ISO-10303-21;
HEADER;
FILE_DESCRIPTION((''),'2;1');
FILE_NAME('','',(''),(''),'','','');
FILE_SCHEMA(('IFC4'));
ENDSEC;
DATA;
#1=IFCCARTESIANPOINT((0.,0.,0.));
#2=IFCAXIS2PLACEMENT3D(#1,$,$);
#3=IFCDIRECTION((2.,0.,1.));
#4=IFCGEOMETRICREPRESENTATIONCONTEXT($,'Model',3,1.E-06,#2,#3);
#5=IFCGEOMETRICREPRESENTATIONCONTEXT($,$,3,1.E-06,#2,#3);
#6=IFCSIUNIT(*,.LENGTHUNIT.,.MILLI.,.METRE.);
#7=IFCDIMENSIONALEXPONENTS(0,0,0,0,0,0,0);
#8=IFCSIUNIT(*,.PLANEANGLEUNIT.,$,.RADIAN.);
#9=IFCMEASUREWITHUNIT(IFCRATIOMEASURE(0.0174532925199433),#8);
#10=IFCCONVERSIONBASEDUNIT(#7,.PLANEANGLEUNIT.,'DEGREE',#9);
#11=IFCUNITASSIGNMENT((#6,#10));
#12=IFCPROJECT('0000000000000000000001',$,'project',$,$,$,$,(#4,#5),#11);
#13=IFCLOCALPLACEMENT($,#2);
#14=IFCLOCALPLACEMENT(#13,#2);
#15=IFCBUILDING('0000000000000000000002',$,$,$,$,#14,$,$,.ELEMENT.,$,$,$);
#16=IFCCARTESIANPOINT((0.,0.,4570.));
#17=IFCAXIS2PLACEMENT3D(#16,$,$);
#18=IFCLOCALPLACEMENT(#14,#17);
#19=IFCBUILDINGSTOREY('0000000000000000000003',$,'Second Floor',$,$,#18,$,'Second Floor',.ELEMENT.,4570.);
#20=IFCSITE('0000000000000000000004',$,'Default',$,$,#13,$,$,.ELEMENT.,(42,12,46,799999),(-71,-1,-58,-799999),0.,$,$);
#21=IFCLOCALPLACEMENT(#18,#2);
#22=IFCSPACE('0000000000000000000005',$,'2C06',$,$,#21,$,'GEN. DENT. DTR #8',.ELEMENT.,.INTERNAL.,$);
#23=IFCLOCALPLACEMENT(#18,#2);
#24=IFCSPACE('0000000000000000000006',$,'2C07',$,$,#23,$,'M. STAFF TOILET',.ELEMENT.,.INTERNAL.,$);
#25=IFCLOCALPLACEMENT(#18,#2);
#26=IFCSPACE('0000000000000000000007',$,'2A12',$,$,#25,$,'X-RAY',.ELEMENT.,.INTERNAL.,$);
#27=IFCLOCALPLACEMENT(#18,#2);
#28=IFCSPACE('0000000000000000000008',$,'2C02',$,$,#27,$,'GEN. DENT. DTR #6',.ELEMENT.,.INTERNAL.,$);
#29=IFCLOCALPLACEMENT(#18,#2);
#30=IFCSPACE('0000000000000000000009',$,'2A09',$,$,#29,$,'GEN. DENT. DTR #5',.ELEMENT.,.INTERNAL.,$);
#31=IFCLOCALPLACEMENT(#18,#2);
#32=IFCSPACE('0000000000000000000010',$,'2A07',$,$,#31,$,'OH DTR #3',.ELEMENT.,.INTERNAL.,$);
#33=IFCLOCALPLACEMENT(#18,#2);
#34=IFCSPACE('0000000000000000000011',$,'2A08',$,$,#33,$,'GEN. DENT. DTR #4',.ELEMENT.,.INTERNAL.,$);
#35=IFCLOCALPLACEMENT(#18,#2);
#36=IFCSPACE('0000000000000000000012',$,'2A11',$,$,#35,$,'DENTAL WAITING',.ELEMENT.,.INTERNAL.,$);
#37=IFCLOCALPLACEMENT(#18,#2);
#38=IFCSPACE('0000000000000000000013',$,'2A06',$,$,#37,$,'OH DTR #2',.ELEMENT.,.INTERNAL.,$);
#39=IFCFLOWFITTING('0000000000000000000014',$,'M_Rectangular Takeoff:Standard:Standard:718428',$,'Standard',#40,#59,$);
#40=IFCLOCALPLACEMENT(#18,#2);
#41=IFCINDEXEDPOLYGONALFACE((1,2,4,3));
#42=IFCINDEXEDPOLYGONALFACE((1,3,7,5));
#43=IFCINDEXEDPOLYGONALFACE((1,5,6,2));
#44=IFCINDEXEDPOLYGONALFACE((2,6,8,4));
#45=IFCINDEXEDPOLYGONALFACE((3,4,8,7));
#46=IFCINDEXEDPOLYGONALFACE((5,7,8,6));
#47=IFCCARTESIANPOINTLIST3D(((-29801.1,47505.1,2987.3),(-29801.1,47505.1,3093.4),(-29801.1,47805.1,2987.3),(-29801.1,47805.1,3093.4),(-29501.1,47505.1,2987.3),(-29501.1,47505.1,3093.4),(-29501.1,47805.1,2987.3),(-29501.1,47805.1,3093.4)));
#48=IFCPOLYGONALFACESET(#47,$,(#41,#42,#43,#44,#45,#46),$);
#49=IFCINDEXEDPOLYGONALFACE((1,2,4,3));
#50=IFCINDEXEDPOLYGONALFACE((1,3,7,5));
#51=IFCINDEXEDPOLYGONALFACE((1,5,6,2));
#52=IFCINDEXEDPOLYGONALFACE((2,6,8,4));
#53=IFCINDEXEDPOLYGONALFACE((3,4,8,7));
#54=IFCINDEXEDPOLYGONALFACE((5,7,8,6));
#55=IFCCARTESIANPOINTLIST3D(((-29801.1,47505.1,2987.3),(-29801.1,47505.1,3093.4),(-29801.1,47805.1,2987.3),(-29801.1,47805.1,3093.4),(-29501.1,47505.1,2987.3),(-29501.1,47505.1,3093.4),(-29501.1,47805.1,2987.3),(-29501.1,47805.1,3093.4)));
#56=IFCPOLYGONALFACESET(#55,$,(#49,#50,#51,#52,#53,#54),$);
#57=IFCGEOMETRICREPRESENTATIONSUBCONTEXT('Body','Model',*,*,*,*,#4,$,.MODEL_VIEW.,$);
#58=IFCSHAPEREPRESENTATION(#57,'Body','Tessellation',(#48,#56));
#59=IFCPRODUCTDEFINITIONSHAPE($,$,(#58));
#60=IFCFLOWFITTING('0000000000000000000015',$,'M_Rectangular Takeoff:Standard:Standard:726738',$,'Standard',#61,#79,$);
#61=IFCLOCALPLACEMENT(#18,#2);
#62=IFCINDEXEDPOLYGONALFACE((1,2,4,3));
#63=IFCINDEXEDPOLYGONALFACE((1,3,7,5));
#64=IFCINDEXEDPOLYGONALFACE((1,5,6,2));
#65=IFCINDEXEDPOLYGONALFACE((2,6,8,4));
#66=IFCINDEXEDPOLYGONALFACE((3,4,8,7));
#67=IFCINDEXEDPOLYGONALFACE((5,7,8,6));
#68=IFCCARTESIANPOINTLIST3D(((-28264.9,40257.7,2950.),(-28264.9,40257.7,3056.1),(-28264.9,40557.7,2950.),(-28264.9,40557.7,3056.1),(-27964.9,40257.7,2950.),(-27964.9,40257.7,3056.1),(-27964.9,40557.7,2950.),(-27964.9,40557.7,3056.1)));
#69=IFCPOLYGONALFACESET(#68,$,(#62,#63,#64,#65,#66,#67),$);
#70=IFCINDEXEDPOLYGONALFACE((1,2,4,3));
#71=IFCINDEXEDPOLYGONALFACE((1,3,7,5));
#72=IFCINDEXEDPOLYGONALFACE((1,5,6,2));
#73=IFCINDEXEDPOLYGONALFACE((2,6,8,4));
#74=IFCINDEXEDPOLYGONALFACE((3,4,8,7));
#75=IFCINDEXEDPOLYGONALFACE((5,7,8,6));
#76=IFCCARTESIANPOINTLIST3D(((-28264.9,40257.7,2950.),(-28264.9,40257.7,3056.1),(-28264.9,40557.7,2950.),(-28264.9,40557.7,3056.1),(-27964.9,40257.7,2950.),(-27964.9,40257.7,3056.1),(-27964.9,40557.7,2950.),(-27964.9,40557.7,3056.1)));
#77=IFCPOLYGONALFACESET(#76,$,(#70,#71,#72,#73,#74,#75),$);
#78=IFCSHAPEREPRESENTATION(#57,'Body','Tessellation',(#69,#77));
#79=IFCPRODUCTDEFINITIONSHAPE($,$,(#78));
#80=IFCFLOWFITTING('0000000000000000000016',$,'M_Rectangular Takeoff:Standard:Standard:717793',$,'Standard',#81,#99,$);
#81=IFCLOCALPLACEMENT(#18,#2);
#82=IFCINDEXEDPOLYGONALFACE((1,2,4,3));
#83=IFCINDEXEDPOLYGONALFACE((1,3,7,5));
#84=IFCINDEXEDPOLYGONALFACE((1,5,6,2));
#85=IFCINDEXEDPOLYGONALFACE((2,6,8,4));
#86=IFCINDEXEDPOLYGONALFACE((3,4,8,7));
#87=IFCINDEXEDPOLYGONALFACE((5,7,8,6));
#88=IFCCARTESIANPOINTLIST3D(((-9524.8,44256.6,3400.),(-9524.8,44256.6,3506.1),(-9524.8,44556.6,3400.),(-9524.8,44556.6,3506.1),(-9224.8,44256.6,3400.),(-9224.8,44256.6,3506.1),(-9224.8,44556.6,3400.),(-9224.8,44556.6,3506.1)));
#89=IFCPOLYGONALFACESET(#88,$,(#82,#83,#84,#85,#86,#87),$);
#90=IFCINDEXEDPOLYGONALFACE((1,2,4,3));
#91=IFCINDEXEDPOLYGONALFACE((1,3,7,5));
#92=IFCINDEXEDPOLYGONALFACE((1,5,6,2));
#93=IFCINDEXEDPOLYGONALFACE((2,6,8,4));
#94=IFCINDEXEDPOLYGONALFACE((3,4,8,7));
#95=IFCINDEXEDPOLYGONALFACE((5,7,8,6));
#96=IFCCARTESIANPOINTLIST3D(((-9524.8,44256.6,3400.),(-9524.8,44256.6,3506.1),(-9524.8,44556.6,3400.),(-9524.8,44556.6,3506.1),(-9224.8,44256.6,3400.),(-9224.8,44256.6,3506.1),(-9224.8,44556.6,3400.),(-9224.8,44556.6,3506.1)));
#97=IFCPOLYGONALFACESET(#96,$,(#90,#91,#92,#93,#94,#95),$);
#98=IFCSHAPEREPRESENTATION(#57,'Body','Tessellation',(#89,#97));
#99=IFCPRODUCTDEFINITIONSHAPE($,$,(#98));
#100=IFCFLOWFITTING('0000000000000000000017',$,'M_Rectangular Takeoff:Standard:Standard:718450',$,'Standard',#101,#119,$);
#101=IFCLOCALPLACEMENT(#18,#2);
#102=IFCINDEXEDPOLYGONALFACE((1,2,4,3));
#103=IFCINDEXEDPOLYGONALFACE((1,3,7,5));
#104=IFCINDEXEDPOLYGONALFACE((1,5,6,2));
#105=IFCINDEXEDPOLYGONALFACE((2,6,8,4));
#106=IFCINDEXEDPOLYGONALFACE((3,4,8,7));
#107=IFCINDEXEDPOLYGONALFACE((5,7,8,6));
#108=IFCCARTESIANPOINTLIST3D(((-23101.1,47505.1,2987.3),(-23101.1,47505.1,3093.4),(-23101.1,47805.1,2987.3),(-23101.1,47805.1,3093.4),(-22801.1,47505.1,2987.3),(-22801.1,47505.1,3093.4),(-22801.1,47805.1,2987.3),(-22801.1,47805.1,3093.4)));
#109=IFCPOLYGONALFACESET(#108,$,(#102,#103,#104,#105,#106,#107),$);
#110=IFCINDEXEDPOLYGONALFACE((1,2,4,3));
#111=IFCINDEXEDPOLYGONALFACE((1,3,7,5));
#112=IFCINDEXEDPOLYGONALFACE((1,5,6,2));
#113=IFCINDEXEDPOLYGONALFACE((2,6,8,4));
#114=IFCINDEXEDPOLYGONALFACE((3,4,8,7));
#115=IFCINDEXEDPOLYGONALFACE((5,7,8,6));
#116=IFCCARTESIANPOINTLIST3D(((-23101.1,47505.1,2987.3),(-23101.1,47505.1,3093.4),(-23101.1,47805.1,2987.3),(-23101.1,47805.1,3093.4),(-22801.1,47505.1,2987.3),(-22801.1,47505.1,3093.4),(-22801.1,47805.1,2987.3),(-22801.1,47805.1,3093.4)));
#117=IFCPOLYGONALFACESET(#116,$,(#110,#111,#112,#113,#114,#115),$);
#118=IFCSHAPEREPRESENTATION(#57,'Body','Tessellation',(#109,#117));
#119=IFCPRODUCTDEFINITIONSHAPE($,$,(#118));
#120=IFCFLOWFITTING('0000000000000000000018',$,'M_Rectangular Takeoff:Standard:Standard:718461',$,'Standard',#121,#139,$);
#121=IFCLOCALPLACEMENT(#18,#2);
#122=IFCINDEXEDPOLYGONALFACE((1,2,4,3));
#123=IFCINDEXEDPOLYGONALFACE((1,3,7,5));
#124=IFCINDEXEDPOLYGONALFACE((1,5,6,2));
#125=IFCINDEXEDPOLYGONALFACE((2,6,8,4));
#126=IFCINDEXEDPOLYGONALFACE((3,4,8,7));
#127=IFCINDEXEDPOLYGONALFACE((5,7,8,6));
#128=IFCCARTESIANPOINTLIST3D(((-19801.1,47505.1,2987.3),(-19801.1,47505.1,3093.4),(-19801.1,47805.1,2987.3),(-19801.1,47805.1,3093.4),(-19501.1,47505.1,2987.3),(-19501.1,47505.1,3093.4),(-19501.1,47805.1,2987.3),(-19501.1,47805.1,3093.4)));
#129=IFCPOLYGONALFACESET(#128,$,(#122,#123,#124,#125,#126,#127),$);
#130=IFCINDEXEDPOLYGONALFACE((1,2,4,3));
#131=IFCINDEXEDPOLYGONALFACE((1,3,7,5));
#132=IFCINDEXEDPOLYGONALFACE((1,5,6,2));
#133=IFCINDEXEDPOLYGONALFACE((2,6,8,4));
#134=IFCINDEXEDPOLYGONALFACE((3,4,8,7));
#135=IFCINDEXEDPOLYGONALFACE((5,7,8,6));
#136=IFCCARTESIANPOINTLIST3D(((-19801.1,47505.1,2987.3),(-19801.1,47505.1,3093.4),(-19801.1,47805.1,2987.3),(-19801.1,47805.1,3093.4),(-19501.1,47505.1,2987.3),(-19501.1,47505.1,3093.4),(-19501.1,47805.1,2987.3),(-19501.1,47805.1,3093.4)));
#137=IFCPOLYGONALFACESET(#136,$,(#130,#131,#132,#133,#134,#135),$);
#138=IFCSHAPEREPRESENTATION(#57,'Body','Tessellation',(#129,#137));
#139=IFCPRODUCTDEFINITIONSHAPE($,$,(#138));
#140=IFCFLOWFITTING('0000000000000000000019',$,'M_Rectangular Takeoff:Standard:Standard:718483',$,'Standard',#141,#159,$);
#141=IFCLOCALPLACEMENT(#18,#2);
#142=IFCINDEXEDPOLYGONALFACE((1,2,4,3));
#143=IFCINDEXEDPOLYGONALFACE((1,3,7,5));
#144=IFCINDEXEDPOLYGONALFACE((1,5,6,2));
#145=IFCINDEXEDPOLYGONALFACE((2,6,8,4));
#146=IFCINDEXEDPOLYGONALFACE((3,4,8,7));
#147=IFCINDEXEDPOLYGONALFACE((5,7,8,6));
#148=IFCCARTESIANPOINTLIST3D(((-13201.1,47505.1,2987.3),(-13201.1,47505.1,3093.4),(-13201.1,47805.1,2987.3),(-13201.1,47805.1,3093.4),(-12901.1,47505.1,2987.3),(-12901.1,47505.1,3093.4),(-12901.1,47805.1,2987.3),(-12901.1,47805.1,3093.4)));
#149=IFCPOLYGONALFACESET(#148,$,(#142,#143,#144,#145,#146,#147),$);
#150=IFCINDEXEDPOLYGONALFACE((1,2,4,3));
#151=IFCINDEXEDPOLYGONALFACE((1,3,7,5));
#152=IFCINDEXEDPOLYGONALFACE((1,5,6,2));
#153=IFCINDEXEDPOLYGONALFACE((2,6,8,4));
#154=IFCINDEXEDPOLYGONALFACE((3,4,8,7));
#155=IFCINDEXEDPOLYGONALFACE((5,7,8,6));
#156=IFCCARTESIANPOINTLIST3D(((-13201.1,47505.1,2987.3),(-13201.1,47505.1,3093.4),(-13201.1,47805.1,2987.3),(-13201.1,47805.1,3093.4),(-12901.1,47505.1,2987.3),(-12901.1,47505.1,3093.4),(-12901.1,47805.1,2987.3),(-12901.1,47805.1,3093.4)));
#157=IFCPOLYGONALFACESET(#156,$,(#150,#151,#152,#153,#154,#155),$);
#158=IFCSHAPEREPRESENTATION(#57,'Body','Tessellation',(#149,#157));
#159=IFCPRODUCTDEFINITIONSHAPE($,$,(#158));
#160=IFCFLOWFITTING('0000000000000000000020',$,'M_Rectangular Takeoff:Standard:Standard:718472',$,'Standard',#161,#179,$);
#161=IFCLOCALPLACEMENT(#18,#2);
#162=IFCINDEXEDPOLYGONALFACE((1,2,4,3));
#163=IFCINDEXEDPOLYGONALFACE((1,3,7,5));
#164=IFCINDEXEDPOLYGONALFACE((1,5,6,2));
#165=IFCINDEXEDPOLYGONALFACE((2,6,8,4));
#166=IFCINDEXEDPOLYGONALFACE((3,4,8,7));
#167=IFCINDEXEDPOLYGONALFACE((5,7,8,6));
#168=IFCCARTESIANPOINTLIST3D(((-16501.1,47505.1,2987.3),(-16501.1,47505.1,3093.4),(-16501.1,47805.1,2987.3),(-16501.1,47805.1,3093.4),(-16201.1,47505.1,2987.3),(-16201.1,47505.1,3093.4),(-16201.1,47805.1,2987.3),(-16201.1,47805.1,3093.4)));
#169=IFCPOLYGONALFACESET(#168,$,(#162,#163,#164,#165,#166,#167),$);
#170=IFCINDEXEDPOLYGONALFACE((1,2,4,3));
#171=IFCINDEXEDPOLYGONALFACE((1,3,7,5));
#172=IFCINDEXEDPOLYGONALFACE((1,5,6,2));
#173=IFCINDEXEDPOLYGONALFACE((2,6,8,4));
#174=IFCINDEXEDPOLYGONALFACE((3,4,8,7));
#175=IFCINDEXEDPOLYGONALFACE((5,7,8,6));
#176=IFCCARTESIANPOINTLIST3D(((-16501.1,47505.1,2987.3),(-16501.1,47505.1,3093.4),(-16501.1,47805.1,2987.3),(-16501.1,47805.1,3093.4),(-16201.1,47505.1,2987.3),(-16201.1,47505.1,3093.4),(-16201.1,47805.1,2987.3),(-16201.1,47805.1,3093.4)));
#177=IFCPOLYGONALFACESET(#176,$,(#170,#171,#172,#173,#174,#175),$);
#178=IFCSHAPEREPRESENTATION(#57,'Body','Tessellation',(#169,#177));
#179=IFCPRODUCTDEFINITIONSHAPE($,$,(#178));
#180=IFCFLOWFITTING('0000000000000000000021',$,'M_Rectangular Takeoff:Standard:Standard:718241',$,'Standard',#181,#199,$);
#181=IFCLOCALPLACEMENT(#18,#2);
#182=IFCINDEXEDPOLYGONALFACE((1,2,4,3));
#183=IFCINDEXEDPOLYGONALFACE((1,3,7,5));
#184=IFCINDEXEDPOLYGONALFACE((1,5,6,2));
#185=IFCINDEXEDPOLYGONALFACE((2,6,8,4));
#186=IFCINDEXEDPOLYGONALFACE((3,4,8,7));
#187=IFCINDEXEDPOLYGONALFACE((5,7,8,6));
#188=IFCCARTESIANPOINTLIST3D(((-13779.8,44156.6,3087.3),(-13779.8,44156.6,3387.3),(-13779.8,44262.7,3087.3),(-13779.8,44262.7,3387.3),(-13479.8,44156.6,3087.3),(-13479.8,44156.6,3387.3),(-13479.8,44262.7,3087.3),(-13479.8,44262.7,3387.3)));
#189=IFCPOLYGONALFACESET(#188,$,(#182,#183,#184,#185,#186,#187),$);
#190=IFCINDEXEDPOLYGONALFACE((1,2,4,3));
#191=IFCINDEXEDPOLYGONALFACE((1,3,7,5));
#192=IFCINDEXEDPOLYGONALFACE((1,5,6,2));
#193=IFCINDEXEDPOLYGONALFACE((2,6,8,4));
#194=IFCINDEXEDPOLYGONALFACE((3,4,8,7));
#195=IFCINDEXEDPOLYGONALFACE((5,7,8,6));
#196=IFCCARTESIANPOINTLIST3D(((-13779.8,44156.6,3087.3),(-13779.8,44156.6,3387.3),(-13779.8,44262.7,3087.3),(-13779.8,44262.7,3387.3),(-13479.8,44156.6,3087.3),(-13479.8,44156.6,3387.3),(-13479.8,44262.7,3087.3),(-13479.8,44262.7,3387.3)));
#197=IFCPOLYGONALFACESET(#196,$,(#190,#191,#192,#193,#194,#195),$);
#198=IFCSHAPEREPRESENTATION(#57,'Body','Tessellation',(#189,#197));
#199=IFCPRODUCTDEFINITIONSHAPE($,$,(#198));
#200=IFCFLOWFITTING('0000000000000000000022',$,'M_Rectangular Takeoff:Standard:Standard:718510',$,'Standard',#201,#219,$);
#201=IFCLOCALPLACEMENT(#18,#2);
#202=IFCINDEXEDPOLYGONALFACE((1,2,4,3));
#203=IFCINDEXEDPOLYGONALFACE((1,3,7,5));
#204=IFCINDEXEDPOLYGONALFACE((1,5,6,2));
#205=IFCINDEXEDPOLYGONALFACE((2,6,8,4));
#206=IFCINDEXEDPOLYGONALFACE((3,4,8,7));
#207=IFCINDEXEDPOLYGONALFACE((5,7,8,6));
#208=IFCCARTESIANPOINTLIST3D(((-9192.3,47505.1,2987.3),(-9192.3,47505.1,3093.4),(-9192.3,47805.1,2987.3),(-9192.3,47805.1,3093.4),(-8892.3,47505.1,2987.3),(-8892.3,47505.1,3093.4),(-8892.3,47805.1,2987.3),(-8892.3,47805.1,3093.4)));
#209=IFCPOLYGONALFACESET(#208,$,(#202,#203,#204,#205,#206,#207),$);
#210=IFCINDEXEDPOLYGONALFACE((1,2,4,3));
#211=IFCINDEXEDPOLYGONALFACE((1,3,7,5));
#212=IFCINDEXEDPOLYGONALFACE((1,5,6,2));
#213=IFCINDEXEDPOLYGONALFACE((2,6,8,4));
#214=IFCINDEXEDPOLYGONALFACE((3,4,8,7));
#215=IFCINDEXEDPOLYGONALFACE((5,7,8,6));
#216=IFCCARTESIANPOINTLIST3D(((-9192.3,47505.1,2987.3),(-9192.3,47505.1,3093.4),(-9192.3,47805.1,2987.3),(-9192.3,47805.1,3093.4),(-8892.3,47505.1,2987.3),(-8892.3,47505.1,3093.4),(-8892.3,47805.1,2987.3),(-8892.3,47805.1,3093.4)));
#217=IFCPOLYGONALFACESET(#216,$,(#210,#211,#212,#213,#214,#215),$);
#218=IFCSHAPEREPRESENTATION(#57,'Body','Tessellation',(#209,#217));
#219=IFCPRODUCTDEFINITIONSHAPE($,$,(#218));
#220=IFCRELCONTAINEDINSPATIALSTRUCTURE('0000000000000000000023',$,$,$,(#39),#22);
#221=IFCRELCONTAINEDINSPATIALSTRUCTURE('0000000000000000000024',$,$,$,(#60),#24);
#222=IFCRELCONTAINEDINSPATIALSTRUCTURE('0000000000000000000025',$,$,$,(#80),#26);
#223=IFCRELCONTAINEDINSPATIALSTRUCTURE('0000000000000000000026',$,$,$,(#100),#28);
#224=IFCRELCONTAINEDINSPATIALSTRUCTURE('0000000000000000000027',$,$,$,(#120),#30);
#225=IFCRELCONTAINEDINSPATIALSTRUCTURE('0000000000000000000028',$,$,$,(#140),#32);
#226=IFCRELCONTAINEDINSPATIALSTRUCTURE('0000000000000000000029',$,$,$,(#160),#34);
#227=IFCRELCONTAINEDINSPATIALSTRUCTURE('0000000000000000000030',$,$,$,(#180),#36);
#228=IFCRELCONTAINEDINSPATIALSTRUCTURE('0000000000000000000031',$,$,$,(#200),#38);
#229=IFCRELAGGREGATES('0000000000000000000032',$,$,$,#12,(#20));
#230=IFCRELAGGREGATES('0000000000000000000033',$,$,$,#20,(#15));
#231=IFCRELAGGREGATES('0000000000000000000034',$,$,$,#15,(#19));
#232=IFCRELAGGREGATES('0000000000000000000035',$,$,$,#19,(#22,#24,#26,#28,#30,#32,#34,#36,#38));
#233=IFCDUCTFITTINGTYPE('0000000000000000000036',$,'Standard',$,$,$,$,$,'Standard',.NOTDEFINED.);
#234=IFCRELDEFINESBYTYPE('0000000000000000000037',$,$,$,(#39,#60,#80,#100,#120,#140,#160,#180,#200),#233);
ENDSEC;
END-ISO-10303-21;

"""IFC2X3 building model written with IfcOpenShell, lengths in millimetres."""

from ifc_helpers import new_model, entity, si_unit, converted_unit, direction, frame, frame_2d, origin, place, context, subcontext, project, spatial, rectangle, extrude, source, transform, mapped, type_object, type_shapes, element, save


model = new_model("IFC2X3")

# Units and contexts
model_context = context("Model", 3, precision=1e-06, world=origin(), true_north=direction((2.0, 0.0, 1.0)))
context_of_model = context(None, 3, precision=1e-06, world=origin(), true_north=direction((2.0, 0.0, 1.0)))
body_context = subcontext(model_context, "Body", "Model", "MODEL_VIEW")
ifc_project = project(units=[si_unit("LENGTHUNIT", "METRE", prefix="MILLI"), converted_unit("PLANEANGLEUNIT", "DEGREE", entity("IfcRatioMeasure", 0.0174532925199433), si_unit("PLANEANGLEUNIT", "RADIAN"), dimensions=[0, 0, 0, 0, 0, 0, 0])], contexts=[model_context, context_of_model])

# Site, building, storey
site_placement = place(None, origin())
site = spatial("IfcSite", under=ifc_project, at=site_placement, Name="Default", CompositionType="ELEMENT", RefLatitude=(42, 12, 46, 799999), RefLongitude=(-71, -1, -58, -799999), RefElevation=0.0)
building_placement = place(site_placement, origin())
building = spatial("IfcBuilding", under=site, at=building_placement, CompositionType="ELEMENT")
storey_placement = place(building_placement, frame((0.0, 0.0, 4570.0)))
storey = spatial("IfcBuildingStorey", under=building, at=storey_placement, Name="Second Floor", LongName="Second Floor", CompositionType="ELEMENT", Elevation=4570.0)

# Shared definitions
space_1_placement = place(storey_placement, origin())
space_1 = spatial("IfcSpace", under=storey, at=space_1_placement, Name="2C06", LongName="GEN. DENT. DTR #8", CompositionType="ELEMENT", InteriorOrExteriorSpace="INTERNAL")

# Flow fitting
duct_fitting_type_1 = type_object("IfcDuctFittingType", Name="Standard", ElementType="Standard", PredefinedType="NOTDEFINED")
shared_shape_1 = source(origin(), body_context, "Body", "SweptSolid", [
    extrude(rectangle(XDim=300.0, YDim=106.1, at=frame_2d((0.0, 0.0), x_axis=(1.0, 0.0))), frame((47.0, 0.0, -150.0), z_axis=(0.0, 0.0, 1.0), x_axis=(0.0, -1.0, 0.0)), (0.0, 0.0, 1.0), 300.0),
    extrude(rectangle(XDim=300.0, YDim=106.1, at=frame_2d((0.0, 0.0), x_axis=(1.0, 0.0))), frame((47.0, 0.0, -150.0), z_axis=(0.0, 0.0, 1.0), x_axis=(0.0, -1.0, 0.0)), (0.0, 0.0, 1.0), 300.0),
])
type_shapes(duct_fitting_type_1, [shared_shape_1])
flow_fitting_1_placement = place(space_1_placement, frame((-29651.1, 47655.1, 3087.3), z_axis=(0.0, -1.0, 0.0), x_axis=(0.0, 0.0, -1.0)))
element("IfcFlowFitting", 1, at=flow_fitting_1_placement, inside=space_1, type_object=duct_fitting_type_1, Name="M_Rectangular Takeoff:Standard:Standard:718428", ObjectType="Standard", context=body_context, shape_type="MappedRepresentation", body=[
    mapped(shared_shape_1, transform((0.0, 0.0, 0.0), scale=1.0)),
])

# Shared definitions
space_2_placement = place(storey_placement, origin())
space_2 = spatial("IfcSpace", under=storey, at=space_2_placement, Name="2C07", LongName="M. STAFF TOILET", CompositionType="ELEMENT", InteriorOrExteriorSpace="INTERNAL")

# Flow fitting
flow_fitting_2_placement = place(space_2_placement, frame((-28114.9, 40407.7, 3050.0), z_axis=(0.0, -1.0, 0.0), x_axis=(0.0, 0.0, -1.0)))
element("IfcFlowFitting", 2, at=flow_fitting_2_placement, inside=space_2, type_object=duct_fitting_type_1, Name="M_Rectangular Takeoff:Standard:Standard:726738", ObjectType="Standard", context=body_context, shape_type="MappedRepresentation", body=[
    mapped(shared_shape_1, transform((0.0, 0.0, 0.0), scale=1.0)),
])

# Shared definitions
space_3_placement = place(storey_placement, origin())
space_3 = spatial("IfcSpace", under=storey, at=space_3_placement, Name="2A12", LongName="X-RAY", CompositionType="ELEMENT", InteriorOrExteriorSpace="INTERNAL")

# Flow fitting
flow_fitting_3_placement = place(space_3_placement, frame((-9374.8, 44406.6, 3500.0), z_axis=(-1.0, 0.0, 0.0), x_axis=(0.0, 0.0, -1.0)))
element("IfcFlowFitting", 3, at=flow_fitting_3_placement, inside=space_3, type_object=duct_fitting_type_1, Name="M_Rectangular Takeoff:Standard:Standard:717793", ObjectType="Standard", context=body_context, shape_type="MappedRepresentation", body=[
    mapped(shared_shape_1, transform((0.0, 0.0, 0.0), scale=1.0)),
])

# Shared definitions
space_4_placement = place(storey_placement, origin())
space_4 = spatial("IfcSpace", under=storey, at=space_4_placement, Name="2C02", LongName="GEN. DENT. DTR #6", CompositionType="ELEMENT", InteriorOrExteriorSpace="INTERNAL")

# Flow fitting
flow_fitting_4_placement = place(space_4_placement, frame((-22951.1, 47655.1, 3087.3), z_axis=(0.0, -1.0, 0.0), x_axis=(0.0, 0.0, -1.0)))
element("IfcFlowFitting", 4, at=flow_fitting_4_placement, inside=space_4, type_object=duct_fitting_type_1, Name="M_Rectangular Takeoff:Standard:Standard:718450", ObjectType="Standard", context=body_context, shape_type="MappedRepresentation", body=[
    mapped(shared_shape_1, transform((0.0, 0.0, 0.0), scale=1.0)),
])

# Shared definitions
space_5_placement = place(storey_placement, origin())
space_5 = spatial("IfcSpace", under=storey, at=space_5_placement, Name="2A09", LongName="GEN. DENT. DTR #5", CompositionType="ELEMENT", InteriorOrExteriorSpace="INTERNAL")

# Flow fitting
flow_fitting_5_placement = place(space_5_placement, frame((-19651.1, 47655.1, 3087.3), z_axis=(0.0, -1.0, 0.0), x_axis=(0.0, 0.0, -1.0)))
element("IfcFlowFitting", 5, at=flow_fitting_5_placement, inside=space_5, type_object=duct_fitting_type_1, Name="M_Rectangular Takeoff:Standard:Standard:718461", ObjectType="Standard", context=body_context, shape_type="MappedRepresentation", body=[
    mapped(shared_shape_1, transform((0.0, 0.0, 0.0), scale=1.0)),
])

# Shared definitions
space_6_placement = place(storey_placement, origin())
space_6 = spatial("IfcSpace", under=storey, at=space_6_placement, Name="2A07", LongName="OH DTR #3", CompositionType="ELEMENT", InteriorOrExteriorSpace="INTERNAL")

# Flow fitting
flow_fitting_6_placement = place(space_6_placement, frame((-13051.1, 47655.1, 3087.3), z_axis=(0.0, -1.0, 0.0), x_axis=(0.0, 0.0, -1.0)))
element("IfcFlowFitting", 6, at=flow_fitting_6_placement, inside=space_6, type_object=duct_fitting_type_1, Name="M_Rectangular Takeoff:Standard:Standard:718483", ObjectType="Standard", context=body_context, shape_type="MappedRepresentation", body=[
    mapped(shared_shape_1, transform((0.0, 0.0, 0.0), scale=1.0)),
])

# Shared definitions
space_7_placement = place(storey_placement, origin())
space_7 = spatial("IfcSpace", under=storey, at=space_7_placement, Name="2A08", LongName="GEN. DENT. DTR #4", CompositionType="ELEMENT", InteriorOrExteriorSpace="INTERNAL")

# Flow fitting
flow_fitting_7_placement = place(space_7_placement, frame((-16351.1, 47655.1, 3087.3), z_axis=(0.0, -1.0, 0.0), x_axis=(0.0, 0.0, -1.0)))
element("IfcFlowFitting", 7, at=flow_fitting_7_placement, inside=space_7, type_object=duct_fitting_type_1, Name="M_Rectangular Takeoff:Standard:Standard:718472", ObjectType="Standard", context=body_context, shape_type="MappedRepresentation", body=[
    mapped(shared_shape_1, transform((0.0, 0.0, 0.0), scale=1.0)),
])

# Shared definitions
space_8_placement = place(storey_placement, origin())
space_8 = spatial("IfcSpace", under=storey, at=space_8_placement, Name="2A11", LongName="DENTAL WAITING", CompositionType="ELEMENT", InteriorOrExteriorSpace="INTERNAL")

# Flow fitting
flow_fitting_8_placement = place(space_8_placement, frame((-13629.8, 44256.6, 3237.3), z_axis=(0.0, 0.0, -1.0), x_axis=(0.0, -1.0, 0.0)))
element("IfcFlowFitting", 8, at=flow_fitting_8_placement, inside=space_8, type_object=duct_fitting_type_1, Name="M_Rectangular Takeoff:Standard:Standard:718241", ObjectType="Standard", context=body_context, shape_type="MappedRepresentation", body=[
    mapped(shared_shape_1, transform((0.0, 0.0, 0.0), scale=1.0)),
])

# Shared definitions
space_9_placement = place(storey_placement, origin())
space_9 = spatial("IfcSpace", under=storey, at=space_9_placement, Name="2A06", LongName="OH DTR #2", CompositionType="ELEMENT", InteriorOrExteriorSpace="INTERNAL")

# Flow fitting
flow_fitting_9_placement = place(space_9_placement, frame((-9042.3, 47655.1, 3087.3), z_axis=(0.0, -1.0, 0.0), x_axis=(0.0, 0.0, -1.0)))
element("IfcFlowFitting", 9, at=flow_fitting_9_placement, inside=space_9, type_object=duct_fitting_type_1, Name="M_Rectangular Takeoff:Standard:Standard:718510", ObjectType="Standard", context=body_context, shape_type="MappedRepresentation", body=[
    mapped(shared_shape_1, transform((0.0, 0.0, 0.0), scale=1.0)),
])

save(model, "model.ifc")
